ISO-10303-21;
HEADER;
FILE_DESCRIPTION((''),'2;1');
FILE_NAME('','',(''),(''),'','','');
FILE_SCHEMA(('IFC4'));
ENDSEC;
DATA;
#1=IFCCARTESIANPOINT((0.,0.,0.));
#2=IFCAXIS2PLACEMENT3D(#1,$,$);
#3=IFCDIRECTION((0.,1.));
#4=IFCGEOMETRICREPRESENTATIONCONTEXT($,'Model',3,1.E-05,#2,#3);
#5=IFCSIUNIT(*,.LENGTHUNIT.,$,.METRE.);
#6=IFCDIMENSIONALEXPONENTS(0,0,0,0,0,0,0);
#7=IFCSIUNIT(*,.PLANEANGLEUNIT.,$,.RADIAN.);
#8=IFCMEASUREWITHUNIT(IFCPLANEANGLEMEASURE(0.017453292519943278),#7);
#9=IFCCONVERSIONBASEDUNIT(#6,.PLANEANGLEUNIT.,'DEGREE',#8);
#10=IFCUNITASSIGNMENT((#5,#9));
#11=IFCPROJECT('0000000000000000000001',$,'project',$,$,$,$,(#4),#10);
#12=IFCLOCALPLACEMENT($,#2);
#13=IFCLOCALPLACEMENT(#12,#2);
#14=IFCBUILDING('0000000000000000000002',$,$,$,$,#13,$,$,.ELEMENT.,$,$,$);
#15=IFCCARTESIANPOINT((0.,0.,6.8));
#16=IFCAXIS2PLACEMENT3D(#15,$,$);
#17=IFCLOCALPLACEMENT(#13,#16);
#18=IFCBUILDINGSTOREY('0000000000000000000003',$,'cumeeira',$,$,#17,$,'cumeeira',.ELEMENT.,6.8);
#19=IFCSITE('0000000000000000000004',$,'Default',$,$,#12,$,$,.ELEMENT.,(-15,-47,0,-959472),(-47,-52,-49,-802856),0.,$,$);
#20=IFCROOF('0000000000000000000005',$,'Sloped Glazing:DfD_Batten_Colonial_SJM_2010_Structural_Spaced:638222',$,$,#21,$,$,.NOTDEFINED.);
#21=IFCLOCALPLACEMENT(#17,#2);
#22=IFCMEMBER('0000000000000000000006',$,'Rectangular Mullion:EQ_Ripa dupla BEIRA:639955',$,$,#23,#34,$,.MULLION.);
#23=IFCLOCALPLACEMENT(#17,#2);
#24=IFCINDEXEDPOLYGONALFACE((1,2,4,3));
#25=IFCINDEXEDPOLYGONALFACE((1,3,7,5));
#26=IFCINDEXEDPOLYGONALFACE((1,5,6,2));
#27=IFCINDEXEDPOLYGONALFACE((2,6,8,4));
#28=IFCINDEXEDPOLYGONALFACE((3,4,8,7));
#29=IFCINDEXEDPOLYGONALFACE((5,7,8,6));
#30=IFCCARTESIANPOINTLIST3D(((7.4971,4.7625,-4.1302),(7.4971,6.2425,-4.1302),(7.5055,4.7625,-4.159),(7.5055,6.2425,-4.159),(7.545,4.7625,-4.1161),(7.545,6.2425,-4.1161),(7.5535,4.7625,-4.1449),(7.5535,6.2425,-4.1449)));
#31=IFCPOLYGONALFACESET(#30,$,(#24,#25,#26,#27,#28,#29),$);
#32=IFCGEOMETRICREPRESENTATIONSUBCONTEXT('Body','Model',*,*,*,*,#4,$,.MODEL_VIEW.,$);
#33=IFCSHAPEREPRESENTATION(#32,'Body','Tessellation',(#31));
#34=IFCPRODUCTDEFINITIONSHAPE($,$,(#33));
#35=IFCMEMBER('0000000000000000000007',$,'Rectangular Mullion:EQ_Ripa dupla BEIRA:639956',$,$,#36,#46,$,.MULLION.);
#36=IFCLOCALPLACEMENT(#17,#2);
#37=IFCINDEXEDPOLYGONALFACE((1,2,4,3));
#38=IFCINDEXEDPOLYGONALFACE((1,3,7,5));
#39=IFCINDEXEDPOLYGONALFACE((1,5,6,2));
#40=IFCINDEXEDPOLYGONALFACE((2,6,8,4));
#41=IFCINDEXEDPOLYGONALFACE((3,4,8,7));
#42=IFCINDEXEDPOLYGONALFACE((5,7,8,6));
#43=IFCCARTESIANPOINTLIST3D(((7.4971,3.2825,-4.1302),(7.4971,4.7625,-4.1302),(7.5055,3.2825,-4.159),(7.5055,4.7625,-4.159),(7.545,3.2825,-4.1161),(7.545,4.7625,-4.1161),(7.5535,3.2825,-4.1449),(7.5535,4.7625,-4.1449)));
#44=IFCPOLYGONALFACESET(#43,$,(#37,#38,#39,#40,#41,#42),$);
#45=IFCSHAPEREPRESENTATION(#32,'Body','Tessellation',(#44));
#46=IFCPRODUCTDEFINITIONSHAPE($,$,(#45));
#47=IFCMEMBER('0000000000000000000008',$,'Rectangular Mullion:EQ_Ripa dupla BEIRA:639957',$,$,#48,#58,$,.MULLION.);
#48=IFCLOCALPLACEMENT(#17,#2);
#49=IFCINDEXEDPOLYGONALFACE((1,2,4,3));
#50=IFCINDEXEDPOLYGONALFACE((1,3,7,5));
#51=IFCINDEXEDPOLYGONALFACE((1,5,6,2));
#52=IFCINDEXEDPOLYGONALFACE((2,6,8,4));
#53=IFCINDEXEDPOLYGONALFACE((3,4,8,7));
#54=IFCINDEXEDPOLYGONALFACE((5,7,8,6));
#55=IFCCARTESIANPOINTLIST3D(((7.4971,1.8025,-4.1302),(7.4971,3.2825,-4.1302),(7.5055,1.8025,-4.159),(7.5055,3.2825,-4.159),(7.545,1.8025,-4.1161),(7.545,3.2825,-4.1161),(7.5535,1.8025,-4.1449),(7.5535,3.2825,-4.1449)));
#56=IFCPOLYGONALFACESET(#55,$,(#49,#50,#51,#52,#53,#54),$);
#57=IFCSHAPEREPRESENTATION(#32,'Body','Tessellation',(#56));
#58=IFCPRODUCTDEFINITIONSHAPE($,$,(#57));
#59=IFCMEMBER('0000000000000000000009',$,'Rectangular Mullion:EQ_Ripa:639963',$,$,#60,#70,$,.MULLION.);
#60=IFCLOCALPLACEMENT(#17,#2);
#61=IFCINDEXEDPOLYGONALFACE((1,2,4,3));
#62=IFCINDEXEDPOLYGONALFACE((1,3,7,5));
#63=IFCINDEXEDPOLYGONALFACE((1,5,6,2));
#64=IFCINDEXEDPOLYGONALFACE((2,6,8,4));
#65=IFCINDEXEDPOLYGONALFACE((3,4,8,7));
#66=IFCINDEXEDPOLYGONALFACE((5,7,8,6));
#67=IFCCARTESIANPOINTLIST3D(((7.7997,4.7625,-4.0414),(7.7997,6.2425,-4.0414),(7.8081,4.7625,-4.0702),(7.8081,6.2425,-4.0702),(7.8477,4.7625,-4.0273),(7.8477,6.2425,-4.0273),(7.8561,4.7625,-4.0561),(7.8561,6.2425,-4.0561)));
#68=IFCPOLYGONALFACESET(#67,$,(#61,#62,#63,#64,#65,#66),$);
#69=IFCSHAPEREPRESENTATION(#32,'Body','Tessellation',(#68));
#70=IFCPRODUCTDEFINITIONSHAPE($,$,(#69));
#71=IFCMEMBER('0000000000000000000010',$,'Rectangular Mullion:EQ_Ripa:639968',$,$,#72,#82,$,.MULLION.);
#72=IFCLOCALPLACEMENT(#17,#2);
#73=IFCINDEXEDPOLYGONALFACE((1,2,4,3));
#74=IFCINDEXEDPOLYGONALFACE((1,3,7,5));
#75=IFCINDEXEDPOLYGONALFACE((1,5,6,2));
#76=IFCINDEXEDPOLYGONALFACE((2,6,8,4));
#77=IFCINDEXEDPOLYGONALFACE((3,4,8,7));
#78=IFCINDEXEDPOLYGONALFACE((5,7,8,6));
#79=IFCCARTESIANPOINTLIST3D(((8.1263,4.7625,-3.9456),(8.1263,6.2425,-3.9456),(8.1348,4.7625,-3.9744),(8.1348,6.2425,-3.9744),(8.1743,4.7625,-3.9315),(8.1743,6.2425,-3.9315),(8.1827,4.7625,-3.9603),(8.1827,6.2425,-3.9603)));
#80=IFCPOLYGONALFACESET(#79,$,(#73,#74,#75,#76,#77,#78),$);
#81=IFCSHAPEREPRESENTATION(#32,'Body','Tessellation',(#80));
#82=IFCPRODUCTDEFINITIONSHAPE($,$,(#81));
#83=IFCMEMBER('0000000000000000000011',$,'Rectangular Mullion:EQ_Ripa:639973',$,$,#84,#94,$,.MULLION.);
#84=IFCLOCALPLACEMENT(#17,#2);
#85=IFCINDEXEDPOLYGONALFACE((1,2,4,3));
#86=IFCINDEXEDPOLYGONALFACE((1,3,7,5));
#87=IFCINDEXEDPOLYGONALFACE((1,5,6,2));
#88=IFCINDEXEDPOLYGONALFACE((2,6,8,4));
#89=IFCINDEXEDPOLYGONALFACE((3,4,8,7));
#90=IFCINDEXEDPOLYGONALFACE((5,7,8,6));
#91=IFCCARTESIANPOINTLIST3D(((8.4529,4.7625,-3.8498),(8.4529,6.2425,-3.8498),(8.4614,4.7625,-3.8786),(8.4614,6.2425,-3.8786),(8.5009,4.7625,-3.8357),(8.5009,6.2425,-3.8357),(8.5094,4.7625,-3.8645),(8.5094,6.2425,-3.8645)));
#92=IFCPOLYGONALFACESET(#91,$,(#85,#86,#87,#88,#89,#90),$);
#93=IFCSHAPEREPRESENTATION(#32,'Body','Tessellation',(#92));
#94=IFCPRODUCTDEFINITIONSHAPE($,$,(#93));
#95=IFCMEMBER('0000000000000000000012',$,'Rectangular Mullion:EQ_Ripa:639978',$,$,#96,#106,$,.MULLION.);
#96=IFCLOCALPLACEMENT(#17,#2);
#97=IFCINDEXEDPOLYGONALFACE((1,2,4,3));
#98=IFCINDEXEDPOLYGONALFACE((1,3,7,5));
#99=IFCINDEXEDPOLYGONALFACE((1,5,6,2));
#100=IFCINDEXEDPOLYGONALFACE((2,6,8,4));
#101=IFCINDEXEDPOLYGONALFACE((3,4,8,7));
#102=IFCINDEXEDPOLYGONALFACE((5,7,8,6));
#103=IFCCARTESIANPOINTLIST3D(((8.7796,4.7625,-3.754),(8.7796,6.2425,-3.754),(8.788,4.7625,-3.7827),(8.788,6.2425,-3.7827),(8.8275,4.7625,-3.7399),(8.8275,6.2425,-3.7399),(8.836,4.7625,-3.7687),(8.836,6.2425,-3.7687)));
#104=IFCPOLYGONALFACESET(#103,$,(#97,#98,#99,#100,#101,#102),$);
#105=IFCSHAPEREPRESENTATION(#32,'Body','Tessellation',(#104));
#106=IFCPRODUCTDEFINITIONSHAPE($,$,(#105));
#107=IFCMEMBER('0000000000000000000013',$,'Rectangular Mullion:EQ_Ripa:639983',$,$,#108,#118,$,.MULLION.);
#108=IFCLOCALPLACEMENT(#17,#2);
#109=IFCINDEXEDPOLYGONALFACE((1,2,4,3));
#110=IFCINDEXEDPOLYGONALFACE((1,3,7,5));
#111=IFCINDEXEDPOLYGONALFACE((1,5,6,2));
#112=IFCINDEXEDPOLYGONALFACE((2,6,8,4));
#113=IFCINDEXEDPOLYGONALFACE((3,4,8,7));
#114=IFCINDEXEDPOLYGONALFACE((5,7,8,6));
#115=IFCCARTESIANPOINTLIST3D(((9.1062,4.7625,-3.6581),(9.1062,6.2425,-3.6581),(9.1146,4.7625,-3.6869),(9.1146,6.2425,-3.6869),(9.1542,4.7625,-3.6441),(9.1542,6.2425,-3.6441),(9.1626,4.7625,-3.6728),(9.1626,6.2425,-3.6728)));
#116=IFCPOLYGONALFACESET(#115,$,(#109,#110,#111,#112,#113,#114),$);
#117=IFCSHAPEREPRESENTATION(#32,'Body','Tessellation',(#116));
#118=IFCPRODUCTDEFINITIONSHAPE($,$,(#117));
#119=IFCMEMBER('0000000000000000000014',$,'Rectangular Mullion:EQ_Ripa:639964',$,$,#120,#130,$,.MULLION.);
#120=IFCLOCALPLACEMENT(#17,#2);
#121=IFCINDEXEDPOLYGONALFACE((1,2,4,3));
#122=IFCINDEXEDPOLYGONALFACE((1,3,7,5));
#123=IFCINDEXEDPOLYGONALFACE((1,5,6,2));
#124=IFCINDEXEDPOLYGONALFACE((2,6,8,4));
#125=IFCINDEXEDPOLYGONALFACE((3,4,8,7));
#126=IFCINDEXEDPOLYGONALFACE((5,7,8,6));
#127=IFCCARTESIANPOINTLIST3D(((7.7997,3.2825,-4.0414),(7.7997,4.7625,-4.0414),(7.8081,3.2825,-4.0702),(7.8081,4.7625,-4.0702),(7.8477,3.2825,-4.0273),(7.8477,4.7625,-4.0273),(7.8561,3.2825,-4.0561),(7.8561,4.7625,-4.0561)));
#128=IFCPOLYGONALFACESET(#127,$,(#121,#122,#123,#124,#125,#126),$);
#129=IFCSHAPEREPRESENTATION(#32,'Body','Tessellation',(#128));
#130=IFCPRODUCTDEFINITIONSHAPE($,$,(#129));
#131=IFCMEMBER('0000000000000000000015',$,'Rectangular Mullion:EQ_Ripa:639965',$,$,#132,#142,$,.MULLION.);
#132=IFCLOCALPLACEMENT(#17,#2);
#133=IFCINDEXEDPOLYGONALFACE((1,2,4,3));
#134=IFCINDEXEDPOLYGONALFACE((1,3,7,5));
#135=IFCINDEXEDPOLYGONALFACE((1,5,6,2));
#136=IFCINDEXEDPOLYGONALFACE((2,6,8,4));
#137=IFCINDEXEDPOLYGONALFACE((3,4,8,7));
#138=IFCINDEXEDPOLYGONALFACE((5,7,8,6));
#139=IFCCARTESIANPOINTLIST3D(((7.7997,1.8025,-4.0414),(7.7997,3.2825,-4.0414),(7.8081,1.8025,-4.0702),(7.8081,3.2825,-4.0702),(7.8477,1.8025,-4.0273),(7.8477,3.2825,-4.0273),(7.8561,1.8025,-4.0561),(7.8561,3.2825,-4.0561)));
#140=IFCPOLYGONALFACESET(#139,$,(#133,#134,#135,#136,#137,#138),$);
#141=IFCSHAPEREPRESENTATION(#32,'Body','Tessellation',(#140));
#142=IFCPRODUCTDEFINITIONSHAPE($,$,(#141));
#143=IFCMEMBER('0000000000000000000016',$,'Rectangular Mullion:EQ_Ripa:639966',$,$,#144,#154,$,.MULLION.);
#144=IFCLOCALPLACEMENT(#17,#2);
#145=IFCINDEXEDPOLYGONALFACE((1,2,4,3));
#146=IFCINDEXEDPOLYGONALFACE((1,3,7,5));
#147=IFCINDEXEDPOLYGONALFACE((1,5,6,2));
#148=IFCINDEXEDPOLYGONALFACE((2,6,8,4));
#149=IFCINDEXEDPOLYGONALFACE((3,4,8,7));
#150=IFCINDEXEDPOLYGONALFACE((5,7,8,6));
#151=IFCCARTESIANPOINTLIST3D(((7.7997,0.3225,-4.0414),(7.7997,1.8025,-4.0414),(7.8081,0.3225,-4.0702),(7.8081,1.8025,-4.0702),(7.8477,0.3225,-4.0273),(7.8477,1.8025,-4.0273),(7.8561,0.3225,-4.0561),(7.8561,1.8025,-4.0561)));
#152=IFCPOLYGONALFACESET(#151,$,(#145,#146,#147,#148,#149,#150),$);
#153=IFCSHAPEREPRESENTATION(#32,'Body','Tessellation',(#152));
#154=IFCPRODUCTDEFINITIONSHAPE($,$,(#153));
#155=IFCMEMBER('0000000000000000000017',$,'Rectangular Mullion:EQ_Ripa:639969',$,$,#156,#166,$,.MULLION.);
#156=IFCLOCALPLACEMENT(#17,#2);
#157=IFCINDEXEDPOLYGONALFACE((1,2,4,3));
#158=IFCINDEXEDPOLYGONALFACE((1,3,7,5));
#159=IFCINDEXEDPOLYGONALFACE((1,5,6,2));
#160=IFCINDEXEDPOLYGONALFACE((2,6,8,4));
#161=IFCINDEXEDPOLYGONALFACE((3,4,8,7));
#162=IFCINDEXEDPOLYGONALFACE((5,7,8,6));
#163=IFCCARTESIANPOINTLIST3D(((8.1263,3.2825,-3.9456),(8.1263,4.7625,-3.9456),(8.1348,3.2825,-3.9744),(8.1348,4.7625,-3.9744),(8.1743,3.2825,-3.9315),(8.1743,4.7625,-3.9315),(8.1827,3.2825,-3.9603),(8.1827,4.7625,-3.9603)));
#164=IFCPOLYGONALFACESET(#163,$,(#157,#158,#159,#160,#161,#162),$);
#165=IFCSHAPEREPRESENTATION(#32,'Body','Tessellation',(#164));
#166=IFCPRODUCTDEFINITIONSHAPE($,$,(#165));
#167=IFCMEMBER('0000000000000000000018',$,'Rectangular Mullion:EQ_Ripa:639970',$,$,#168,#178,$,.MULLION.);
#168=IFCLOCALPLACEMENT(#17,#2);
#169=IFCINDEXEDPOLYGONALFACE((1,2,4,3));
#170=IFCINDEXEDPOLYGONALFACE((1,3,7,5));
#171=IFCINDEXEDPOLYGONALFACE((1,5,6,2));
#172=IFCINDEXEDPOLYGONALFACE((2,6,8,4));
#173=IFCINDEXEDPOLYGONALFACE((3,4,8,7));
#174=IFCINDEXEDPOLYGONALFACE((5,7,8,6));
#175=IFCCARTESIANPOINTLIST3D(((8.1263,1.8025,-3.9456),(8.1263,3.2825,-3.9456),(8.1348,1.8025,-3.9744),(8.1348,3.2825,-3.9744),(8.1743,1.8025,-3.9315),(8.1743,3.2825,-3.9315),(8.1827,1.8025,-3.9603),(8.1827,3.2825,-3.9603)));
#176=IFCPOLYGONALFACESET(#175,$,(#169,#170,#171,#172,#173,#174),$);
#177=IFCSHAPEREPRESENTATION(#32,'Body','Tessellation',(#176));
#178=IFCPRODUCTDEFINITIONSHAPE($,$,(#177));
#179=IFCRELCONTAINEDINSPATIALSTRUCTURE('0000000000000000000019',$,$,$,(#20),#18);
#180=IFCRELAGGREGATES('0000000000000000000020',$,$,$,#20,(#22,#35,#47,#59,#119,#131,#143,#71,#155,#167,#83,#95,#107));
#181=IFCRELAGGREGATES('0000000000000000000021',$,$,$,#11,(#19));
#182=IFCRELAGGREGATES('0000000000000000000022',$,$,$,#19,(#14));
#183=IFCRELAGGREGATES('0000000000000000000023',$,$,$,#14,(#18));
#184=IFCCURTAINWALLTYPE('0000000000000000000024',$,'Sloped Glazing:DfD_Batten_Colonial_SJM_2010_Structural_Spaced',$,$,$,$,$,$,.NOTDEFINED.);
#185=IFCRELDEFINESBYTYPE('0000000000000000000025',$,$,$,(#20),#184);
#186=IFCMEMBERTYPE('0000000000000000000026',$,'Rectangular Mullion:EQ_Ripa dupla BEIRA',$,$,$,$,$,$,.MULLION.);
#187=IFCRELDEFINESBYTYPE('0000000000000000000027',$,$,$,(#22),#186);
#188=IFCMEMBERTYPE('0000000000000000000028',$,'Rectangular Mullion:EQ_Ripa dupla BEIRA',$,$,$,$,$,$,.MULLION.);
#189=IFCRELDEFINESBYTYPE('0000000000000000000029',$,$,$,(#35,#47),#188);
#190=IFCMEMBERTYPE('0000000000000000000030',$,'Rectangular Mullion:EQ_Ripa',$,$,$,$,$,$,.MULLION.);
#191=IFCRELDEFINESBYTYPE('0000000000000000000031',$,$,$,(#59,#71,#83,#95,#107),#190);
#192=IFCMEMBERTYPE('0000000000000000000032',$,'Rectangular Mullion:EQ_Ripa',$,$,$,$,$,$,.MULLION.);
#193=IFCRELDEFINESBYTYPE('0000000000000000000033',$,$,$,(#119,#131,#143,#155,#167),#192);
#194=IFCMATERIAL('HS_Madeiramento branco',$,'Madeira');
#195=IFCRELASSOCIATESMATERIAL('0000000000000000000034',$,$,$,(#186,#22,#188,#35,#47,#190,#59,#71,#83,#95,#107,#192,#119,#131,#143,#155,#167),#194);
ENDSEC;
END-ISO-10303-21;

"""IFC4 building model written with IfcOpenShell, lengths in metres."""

from ifc_helpers import new_model, entity, si_unit, converted_unit, direction, frame, origin, place, context, subcontext, project, spatial, indexed_curve, outline, extrude, source, transform, mapped, material, type_object, type_shapes, element, aggregate, save


model = new_model("IFC4")

# Units and contexts
model_context = context("Model", 3, precision=1e-05, world=origin(), true_north=direction((0.0, 1.0)))
body_context = subcontext(model_context, "Body", "Model", "MODEL_VIEW")
ifc_project = project(units=[si_unit("LENGTHUNIT", "METRE"), converted_unit("PLANEANGLEUNIT", "DEGREE", entity("IfcPlaneAngleMeasure", 0.017453292519943278), si_unit("PLANEANGLEUNIT", "RADIAN"), dimensions=[0, 0, 0, 0, 0, 0, 0])], contexts=[model_context])

# Site, building, storey
site_placement = place(None, origin())
site = spatial("IfcSite", under=ifc_project, at=site_placement, Name="Default", CompositionType="ELEMENT", RefLatitude=(-15, -47, 0, -959472), RefLongitude=(-47, -52, -49, -802856), RefElevation=0.0)
building_placement = place(site_placement, origin())
building = spatial("IfcBuilding", under=site, at=building_placement, CompositionType="ELEMENT")
storey_placement = place(building_placement, frame((0.0, 0.0, 6.8)))
storey = spatial("IfcBuildingStorey", under=building, at=storey_placement, Name="cumeeira", LongName="cumeeira", CompositionType="ELEMENT", Elevation=6.8)

# Roof, members
curtain_wall_type = type_object("IfcCurtainWallType", Name="Sloped Glazing:DfD_Batten_Colonial_SJM_2010_Structural_Spaced", PredefinedType="NOTDEFINED")
roof_placement = place(storey_placement, frame((0.0, 0.0, -6.8)))
roof = element("IfcRoof", 1, at=roof_placement, inside=storey, type_object=curtain_wall_type, Name="Sloped Glazing:DfD_Batten_Colonial_SJM_2010_Structural_Spaced:638222", PredefinedType="NOTDEFINED")
ifc_material = material(Name="HS_Madeiramento branco", Category="Madeira")
member_type_1 = type_object("IfcMemberType", Name="Rectangular Mullion:EQ_Ripa dupla BEIRA", PredefinedType="MULLION", material=ifc_material)
shared_shape_1 = source(origin(), body_context, "Body", "SweptSolid", [
    extrude(outline(indexed_curve([(-0.025, -0.015), (0.025, -0.015), (0.025, 0.015), (-0.025, 0.015), (-0.025, -0.015)], self_intersect=False)), frame((-0.025, 0.0, -1.48), z_axis=(0.0, 0.0, 1.0), x_axis=(-1.0, 0.0, 0.0)), (0.0, 0.0, 1.0), 1.48),
])
type_shapes(member_type_1, [shared_shape_1])
member_1_placement = place(roof_placement, frame((7.5013, 4.7625, 2.6554), z_axis=(0.0, -1.0, 0.0), x_axis=(-0.95956, 0.0, -0.281504)))
member_1 = element("IfcMember", 2, at=member_1_placement, type_object=member_type_1, material=ifc_material, Name="Rectangular Mullion:EQ_Ripa dupla BEIRA:639955", PredefinedType="MULLION", context=body_context, shape_type="MappedRepresentation", body=[
    mapped(shared_shape_1, transform((0.0, 0.0, 0.0), scale=1.0)),
])
member_type_2 = type_object("IfcMemberType", Name="Rectangular Mullion:EQ_Ripa dupla BEIRA", PredefinedType="MULLION", material=ifc_material)
shared_shape_2 = source(origin(), body_context, "Body", "SweptSolid", [
    extrude(outline(indexed_curve([(-0.025, -0.015), (0.025, -0.015), (0.025, 0.015), (-0.025, 0.015), (-0.025, -0.015)], self_intersect=False)), frame((-0.025, 0.0, -1.48), z_axis=(0.0, 0.0, 1.0), x_axis=(-1.0, 0.0, 0.0)), (0.0, 0.0, 1.0), 1.48),
])
type_shapes(member_type_2, [shared_shape_2])
member_2_placement = place(roof_placement, frame((7.5013, 3.2825, 2.6554), z_axis=(0.0, -1.0, 0.0), x_axis=(-0.95956, 0.0, -0.281504)))
member_2 = element("IfcMember", 3, at=member_2_placement, type_object=member_type_2, material=ifc_material, Name="Rectangular Mullion:EQ_Ripa dupla BEIRA:639956", PredefinedType="MULLION", context=body_context, shape_type="MappedRepresentation", body=[
    mapped(shared_shape_2, transform((0.0, 0.0, 0.0), scale=1.0)),
])
member_3_placement = place(roof_placement, frame((7.5013, 1.8025, 2.6554), z_axis=(0.0, -1.0, 0.0), x_axis=(-0.95956, 0.0, -0.281504)))
member_3 = element("IfcMember", 4, at=member_3_placement, type_object=member_type_2, material=ifc_material, Name="Rectangular Mullion:EQ_Ripa dupla BEIRA:639957", PredefinedType="MULLION", context=body_context, shape_type="MappedRepresentation", body=[
    mapped(shared_shape_2, transform((0.0, 0.0, 0.0), scale=1.0)),
])
member_type_3 = type_object("IfcMemberType", Name="Rectangular Mullion:EQ_Ripa", PredefinedType="MULLION", material=ifc_material)
shared_shape_3 = source(origin(), body_context, "Body", "SweptSolid", [
    extrude(outline(indexed_curve([(-0.025, -0.015), (0.025, -0.015), (0.025, 0.015), (-0.025, 0.015), (-0.025, -0.015)], self_intersect=False)), frame((0.0, 0.0, -1.48), z_axis=(0.0, 0.0, 1.0), x_axis=(-1.0, 0.0, 0.0)), (0.0, 0.0, 1.0), 1.48),
])
type_shapes(member_type_3, [shared_shape_3])
member_4_placement = place(roof_placement, frame((7.8279, 6.2425, 2.7512), z_axis=(0.0, 1.0, 0.0), x_axis=(0.95956, 0.0, 0.281504)))
member_4 = element("IfcMember", 5, at=member_4_placement, type_object=member_type_3, material=ifc_material, Name="Rectangular Mullion:EQ_Ripa:639963", PredefinedType="MULLION", context=body_context, shape_type="MappedRepresentation", body=[
    mapped(shared_shape_3, transform((0.0, 0.0, 0.0), scale=1.0)),
])
member_5_placement = place(roof_placement, frame((8.1545, 6.2425, 2.847), z_axis=(0.0, 1.0, 0.0), x_axis=(0.95956, 0.0, 0.281504)))
member_5 = element("IfcMember", 6, at=member_5_placement, type_object=member_type_3, material=ifc_material, Name="Rectangular Mullion:EQ_Ripa:639968", PredefinedType="MULLION", context=body_context, shape_type="MappedRepresentation", body=[
    mapped(shared_shape_3, transform((0.0, 0.0, 0.0), scale=1.0)),
])
member_6_placement = place(roof_placement, frame((8.4812, 6.2425, 2.9429), z_axis=(0.0, 1.0, 0.0), x_axis=(0.95956, 0.0, 0.281504)))
member_6 = element("IfcMember", 7, at=member_6_placement, type_object=member_type_3, material=ifc_material, Name="Rectangular Mullion:EQ_Ripa:639973", PredefinedType="MULLION", context=body_context, shape_type="MappedRepresentation", body=[
    mapped(shared_shape_3, transform((0.0, 0.0, 0.0), scale=1.0)),
])
member_7_placement = place(roof_placement, frame((8.8078, 6.2425, 3.0387), z_axis=(0.0, 1.0, 0.0), x_axis=(0.95956, 0.0, 0.281504)))
member_7 = element("IfcMember", 8, at=member_7_placement, type_object=member_type_3, material=ifc_material, Name="Rectangular Mullion:EQ_Ripa:639978", PredefinedType="MULLION", context=body_context, shape_type="MappedRepresentation", body=[
    mapped(shared_shape_3, transform((0.0, 0.0, 0.0), scale=1.0)),
])
member_8_placement = place(roof_placement, frame((9.1344, 6.2425, 3.1345), z_axis=(0.0, 1.0, 0.0), x_axis=(0.95956, 0.0, 0.281504)))
member_8 = element("IfcMember", 9, at=member_8_placement, type_object=member_type_3, material=ifc_material, Name="Rectangular Mullion:EQ_Ripa:639983", PredefinedType="MULLION", context=body_context, shape_type="MappedRepresentation", body=[
    mapped(shared_shape_3, transform((0.0, 0.0, 0.0), scale=1.0)),
])
member_type_4 = type_object("IfcMemberType", Name="Rectangular Mullion:EQ_Ripa", PredefinedType="MULLION", material=ifc_material)
shared_shape_4 = source(origin(), body_context, "Body", "SweptSolid", [
    extrude(outline(indexed_curve([(-0.025, -0.015), (0.025, -0.015), (0.025, 0.015), (-0.025, 0.015), (-0.025, -0.015)], self_intersect=False)), frame((0.0, 0.0, -1.48), z_axis=(0.0, 0.0, 1.0), x_axis=(-1.0, 0.0, 0.0)), (0.0, 0.0, 1.0), 1.48),
])
type_shapes(member_type_4, [shared_shape_4])
member_9_placement = place(roof_placement, frame((7.8279, 4.7625, 2.7512), z_axis=(0.0, 1.0, 0.0), x_axis=(0.95956, 0.0, 0.281504)))
member_9 = element("IfcMember", 10, at=member_9_placement, type_object=member_type_4, material=ifc_material, Name="Rectangular Mullion:EQ_Ripa:639964", PredefinedType="MULLION", context=body_context, shape_type="MappedRepresentation", body=[
    mapped(shared_shape_4, transform((0.0, 0.0, 0.0), scale=1.0)),
])
member_10_placement = place(roof_placement, frame((7.8279, 3.2825, 2.7512), z_axis=(0.0, 1.0, 0.0), x_axis=(0.95956, 0.0, 0.281504)))
member_10 = element("IfcMember", 11, at=member_10_placement, type_object=member_type_4, material=ifc_material, Name="Rectangular Mullion:EQ_Ripa:639965", PredefinedType="MULLION", context=body_context, shape_type="MappedRepresentation", body=[
    mapped(shared_shape_4, transform((0.0, 0.0, 0.0), scale=1.0)),
])
member_11_placement = place(roof_placement, frame((7.8279, 1.8025, 2.7512), z_axis=(0.0, 1.0, 0.0), x_axis=(0.95956, 0.0, 0.281504)))
member_11 = element("IfcMember", 12, at=member_11_placement, type_object=member_type_4, material=ifc_material, Name="Rectangular Mullion:EQ_Ripa:639966", PredefinedType="MULLION", context=body_context, shape_type="MappedRepresentation", body=[
    mapped(shared_shape_4, transform((0.0, 0.0, 0.0), scale=1.0)),
])
member_12_placement = place(roof_placement, frame((8.1545, 4.7625, 2.847), z_axis=(0.0, 1.0, 0.0), x_axis=(0.95956, 0.0, 0.281504)))
member_12 = element("IfcMember", 13, at=member_12_placement, type_object=member_type_4, material=ifc_material, Name="Rectangular Mullion:EQ_Ripa:639969", PredefinedType="MULLION", context=body_context, shape_type="MappedRepresentation", body=[
    mapped(shared_shape_4, transform((0.0, 0.0, 0.0), scale=1.0)),
])
member_13_placement = place(roof_placement, frame((8.1545, 3.2825, 2.847), z_axis=(0.0, 1.0, 0.0), x_axis=(0.95956, 0.0, 0.281504)))
member_13 = element("IfcMember", 14, at=member_13_placement, type_object=member_type_4, material=ifc_material, Name="Rectangular Mullion:EQ_Ripa:639970", PredefinedType="MULLION", context=body_context, shape_type="MappedRepresentation", body=[
    mapped(shared_shape_4, transform((0.0, 0.0, 0.0), scale=1.0)),
])
aggregate(roof, [member_1, member_2, member_3, member_4, member_9, member_10, member_11, member_5, member_12, member_13, member_6, member_7, member_8])

save(model, "model.ifc")
